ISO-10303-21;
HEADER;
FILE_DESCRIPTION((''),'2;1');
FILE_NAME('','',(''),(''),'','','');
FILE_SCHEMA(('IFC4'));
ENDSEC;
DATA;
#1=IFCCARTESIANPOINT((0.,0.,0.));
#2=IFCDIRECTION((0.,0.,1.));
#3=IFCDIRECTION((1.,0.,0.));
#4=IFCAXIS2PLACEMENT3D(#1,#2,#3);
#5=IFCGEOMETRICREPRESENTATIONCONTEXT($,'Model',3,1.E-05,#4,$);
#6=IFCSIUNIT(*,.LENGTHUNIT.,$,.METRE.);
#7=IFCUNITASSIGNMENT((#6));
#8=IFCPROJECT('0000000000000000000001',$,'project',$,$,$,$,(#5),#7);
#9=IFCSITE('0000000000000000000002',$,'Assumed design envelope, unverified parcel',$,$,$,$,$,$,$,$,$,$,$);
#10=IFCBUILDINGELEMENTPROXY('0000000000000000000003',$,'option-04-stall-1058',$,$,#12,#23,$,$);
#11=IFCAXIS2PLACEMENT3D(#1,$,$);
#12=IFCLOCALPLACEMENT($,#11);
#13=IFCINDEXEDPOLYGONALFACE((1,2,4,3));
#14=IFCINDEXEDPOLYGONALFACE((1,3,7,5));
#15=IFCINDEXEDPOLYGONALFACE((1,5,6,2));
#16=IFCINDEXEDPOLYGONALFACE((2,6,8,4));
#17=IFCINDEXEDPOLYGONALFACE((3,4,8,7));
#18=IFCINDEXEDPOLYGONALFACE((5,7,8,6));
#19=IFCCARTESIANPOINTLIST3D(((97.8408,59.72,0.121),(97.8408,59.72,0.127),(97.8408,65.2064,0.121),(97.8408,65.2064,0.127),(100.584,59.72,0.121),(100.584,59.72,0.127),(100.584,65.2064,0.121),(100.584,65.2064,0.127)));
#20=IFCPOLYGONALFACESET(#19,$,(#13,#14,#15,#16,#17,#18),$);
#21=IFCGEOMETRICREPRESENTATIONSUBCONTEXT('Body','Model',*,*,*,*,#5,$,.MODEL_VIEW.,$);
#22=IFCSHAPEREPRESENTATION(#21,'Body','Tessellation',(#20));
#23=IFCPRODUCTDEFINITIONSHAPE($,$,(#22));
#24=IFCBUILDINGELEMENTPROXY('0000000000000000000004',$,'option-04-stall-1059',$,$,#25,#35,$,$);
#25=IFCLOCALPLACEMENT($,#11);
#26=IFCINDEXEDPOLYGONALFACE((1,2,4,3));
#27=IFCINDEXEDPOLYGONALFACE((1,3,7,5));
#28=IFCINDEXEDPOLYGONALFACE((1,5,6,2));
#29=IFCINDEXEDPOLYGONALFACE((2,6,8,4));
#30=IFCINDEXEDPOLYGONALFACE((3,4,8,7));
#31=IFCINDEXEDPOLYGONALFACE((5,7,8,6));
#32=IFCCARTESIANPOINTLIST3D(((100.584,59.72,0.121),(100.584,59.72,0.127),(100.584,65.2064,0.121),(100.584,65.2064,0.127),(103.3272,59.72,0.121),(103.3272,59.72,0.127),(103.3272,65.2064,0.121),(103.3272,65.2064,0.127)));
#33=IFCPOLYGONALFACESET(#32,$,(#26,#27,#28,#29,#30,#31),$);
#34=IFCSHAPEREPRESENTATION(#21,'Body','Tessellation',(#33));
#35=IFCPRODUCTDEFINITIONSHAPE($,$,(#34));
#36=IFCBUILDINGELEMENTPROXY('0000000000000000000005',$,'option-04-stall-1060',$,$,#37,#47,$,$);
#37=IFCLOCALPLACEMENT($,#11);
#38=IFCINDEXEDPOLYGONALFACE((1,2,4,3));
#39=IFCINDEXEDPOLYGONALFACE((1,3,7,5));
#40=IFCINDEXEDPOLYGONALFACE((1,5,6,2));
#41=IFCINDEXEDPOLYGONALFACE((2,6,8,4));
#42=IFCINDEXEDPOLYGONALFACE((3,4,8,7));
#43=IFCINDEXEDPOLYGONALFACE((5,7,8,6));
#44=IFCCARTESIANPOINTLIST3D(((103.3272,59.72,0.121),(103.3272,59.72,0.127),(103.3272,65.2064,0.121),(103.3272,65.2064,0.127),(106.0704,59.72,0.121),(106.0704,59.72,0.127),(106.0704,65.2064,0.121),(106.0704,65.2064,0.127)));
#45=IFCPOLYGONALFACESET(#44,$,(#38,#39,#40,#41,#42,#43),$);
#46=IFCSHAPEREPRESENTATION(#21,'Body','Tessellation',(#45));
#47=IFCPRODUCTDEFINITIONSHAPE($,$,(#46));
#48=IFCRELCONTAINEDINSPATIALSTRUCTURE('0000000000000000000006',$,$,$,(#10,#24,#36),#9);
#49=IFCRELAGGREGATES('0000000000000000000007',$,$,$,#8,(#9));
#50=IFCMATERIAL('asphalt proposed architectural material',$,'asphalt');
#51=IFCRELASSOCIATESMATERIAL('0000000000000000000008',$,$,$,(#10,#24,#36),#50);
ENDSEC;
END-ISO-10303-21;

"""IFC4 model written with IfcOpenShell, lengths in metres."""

from ifc_helpers import new_model, si_unit, frame, origin_with_axes, place, context, subcontext, project, spatial, rectangle, extrude, material, element, save


model = new_model("IFC4")

# Units and contexts
model_context = context("Model", 3, precision=1e-05, world=origin_with_axes())
body_context = subcontext(model_context, "Body", "Model", "MODEL_VIEW")
ifc_project = project(units=[si_unit("LENGTHUNIT", "METRE")], contexts=[model_context])

# Site
site = spatial("IfcSite", under=ifc_project, Name="Assumed design envelope, unverified parcel")

# Building element proxies
ifc_material = material(Name="asphalt proposed architectural material", Category="asphalt")
for number, where, z_axis, x_axis, name in (
    (1, (99.2124, 62.4632, 0.121), (0.0, 0.0, 1.0), (1.0, 0.0, 0.0), "option-04-stall-1058"),
    (2, (101.9556, 62.4632, 0.121), (0.0, 0.0, 1.0), (1.0, 0.0, 0.0), "option-04-stall-1059"),
    (3, (104.6988, 62.4632, 0.121), (0.0, 0.0, 1.0), (1.0, 0.0, 0.0), "option-04-stall-1060"),
):
    element("IfcBuildingElementProxy", number, at=place(None, frame(where, z_axis=z_axis, x_axis=x_axis)), inside=site, material=ifc_material, Name=name, context=body_context, shape_type="SweptSolid", body=[
        extrude(rectangle(XDim=2.7432, YDim=5.4864), origin_with_axes(), (0.0, 0.0, 1.0), 0.006),
    ])

save(model, "model.ifc")
